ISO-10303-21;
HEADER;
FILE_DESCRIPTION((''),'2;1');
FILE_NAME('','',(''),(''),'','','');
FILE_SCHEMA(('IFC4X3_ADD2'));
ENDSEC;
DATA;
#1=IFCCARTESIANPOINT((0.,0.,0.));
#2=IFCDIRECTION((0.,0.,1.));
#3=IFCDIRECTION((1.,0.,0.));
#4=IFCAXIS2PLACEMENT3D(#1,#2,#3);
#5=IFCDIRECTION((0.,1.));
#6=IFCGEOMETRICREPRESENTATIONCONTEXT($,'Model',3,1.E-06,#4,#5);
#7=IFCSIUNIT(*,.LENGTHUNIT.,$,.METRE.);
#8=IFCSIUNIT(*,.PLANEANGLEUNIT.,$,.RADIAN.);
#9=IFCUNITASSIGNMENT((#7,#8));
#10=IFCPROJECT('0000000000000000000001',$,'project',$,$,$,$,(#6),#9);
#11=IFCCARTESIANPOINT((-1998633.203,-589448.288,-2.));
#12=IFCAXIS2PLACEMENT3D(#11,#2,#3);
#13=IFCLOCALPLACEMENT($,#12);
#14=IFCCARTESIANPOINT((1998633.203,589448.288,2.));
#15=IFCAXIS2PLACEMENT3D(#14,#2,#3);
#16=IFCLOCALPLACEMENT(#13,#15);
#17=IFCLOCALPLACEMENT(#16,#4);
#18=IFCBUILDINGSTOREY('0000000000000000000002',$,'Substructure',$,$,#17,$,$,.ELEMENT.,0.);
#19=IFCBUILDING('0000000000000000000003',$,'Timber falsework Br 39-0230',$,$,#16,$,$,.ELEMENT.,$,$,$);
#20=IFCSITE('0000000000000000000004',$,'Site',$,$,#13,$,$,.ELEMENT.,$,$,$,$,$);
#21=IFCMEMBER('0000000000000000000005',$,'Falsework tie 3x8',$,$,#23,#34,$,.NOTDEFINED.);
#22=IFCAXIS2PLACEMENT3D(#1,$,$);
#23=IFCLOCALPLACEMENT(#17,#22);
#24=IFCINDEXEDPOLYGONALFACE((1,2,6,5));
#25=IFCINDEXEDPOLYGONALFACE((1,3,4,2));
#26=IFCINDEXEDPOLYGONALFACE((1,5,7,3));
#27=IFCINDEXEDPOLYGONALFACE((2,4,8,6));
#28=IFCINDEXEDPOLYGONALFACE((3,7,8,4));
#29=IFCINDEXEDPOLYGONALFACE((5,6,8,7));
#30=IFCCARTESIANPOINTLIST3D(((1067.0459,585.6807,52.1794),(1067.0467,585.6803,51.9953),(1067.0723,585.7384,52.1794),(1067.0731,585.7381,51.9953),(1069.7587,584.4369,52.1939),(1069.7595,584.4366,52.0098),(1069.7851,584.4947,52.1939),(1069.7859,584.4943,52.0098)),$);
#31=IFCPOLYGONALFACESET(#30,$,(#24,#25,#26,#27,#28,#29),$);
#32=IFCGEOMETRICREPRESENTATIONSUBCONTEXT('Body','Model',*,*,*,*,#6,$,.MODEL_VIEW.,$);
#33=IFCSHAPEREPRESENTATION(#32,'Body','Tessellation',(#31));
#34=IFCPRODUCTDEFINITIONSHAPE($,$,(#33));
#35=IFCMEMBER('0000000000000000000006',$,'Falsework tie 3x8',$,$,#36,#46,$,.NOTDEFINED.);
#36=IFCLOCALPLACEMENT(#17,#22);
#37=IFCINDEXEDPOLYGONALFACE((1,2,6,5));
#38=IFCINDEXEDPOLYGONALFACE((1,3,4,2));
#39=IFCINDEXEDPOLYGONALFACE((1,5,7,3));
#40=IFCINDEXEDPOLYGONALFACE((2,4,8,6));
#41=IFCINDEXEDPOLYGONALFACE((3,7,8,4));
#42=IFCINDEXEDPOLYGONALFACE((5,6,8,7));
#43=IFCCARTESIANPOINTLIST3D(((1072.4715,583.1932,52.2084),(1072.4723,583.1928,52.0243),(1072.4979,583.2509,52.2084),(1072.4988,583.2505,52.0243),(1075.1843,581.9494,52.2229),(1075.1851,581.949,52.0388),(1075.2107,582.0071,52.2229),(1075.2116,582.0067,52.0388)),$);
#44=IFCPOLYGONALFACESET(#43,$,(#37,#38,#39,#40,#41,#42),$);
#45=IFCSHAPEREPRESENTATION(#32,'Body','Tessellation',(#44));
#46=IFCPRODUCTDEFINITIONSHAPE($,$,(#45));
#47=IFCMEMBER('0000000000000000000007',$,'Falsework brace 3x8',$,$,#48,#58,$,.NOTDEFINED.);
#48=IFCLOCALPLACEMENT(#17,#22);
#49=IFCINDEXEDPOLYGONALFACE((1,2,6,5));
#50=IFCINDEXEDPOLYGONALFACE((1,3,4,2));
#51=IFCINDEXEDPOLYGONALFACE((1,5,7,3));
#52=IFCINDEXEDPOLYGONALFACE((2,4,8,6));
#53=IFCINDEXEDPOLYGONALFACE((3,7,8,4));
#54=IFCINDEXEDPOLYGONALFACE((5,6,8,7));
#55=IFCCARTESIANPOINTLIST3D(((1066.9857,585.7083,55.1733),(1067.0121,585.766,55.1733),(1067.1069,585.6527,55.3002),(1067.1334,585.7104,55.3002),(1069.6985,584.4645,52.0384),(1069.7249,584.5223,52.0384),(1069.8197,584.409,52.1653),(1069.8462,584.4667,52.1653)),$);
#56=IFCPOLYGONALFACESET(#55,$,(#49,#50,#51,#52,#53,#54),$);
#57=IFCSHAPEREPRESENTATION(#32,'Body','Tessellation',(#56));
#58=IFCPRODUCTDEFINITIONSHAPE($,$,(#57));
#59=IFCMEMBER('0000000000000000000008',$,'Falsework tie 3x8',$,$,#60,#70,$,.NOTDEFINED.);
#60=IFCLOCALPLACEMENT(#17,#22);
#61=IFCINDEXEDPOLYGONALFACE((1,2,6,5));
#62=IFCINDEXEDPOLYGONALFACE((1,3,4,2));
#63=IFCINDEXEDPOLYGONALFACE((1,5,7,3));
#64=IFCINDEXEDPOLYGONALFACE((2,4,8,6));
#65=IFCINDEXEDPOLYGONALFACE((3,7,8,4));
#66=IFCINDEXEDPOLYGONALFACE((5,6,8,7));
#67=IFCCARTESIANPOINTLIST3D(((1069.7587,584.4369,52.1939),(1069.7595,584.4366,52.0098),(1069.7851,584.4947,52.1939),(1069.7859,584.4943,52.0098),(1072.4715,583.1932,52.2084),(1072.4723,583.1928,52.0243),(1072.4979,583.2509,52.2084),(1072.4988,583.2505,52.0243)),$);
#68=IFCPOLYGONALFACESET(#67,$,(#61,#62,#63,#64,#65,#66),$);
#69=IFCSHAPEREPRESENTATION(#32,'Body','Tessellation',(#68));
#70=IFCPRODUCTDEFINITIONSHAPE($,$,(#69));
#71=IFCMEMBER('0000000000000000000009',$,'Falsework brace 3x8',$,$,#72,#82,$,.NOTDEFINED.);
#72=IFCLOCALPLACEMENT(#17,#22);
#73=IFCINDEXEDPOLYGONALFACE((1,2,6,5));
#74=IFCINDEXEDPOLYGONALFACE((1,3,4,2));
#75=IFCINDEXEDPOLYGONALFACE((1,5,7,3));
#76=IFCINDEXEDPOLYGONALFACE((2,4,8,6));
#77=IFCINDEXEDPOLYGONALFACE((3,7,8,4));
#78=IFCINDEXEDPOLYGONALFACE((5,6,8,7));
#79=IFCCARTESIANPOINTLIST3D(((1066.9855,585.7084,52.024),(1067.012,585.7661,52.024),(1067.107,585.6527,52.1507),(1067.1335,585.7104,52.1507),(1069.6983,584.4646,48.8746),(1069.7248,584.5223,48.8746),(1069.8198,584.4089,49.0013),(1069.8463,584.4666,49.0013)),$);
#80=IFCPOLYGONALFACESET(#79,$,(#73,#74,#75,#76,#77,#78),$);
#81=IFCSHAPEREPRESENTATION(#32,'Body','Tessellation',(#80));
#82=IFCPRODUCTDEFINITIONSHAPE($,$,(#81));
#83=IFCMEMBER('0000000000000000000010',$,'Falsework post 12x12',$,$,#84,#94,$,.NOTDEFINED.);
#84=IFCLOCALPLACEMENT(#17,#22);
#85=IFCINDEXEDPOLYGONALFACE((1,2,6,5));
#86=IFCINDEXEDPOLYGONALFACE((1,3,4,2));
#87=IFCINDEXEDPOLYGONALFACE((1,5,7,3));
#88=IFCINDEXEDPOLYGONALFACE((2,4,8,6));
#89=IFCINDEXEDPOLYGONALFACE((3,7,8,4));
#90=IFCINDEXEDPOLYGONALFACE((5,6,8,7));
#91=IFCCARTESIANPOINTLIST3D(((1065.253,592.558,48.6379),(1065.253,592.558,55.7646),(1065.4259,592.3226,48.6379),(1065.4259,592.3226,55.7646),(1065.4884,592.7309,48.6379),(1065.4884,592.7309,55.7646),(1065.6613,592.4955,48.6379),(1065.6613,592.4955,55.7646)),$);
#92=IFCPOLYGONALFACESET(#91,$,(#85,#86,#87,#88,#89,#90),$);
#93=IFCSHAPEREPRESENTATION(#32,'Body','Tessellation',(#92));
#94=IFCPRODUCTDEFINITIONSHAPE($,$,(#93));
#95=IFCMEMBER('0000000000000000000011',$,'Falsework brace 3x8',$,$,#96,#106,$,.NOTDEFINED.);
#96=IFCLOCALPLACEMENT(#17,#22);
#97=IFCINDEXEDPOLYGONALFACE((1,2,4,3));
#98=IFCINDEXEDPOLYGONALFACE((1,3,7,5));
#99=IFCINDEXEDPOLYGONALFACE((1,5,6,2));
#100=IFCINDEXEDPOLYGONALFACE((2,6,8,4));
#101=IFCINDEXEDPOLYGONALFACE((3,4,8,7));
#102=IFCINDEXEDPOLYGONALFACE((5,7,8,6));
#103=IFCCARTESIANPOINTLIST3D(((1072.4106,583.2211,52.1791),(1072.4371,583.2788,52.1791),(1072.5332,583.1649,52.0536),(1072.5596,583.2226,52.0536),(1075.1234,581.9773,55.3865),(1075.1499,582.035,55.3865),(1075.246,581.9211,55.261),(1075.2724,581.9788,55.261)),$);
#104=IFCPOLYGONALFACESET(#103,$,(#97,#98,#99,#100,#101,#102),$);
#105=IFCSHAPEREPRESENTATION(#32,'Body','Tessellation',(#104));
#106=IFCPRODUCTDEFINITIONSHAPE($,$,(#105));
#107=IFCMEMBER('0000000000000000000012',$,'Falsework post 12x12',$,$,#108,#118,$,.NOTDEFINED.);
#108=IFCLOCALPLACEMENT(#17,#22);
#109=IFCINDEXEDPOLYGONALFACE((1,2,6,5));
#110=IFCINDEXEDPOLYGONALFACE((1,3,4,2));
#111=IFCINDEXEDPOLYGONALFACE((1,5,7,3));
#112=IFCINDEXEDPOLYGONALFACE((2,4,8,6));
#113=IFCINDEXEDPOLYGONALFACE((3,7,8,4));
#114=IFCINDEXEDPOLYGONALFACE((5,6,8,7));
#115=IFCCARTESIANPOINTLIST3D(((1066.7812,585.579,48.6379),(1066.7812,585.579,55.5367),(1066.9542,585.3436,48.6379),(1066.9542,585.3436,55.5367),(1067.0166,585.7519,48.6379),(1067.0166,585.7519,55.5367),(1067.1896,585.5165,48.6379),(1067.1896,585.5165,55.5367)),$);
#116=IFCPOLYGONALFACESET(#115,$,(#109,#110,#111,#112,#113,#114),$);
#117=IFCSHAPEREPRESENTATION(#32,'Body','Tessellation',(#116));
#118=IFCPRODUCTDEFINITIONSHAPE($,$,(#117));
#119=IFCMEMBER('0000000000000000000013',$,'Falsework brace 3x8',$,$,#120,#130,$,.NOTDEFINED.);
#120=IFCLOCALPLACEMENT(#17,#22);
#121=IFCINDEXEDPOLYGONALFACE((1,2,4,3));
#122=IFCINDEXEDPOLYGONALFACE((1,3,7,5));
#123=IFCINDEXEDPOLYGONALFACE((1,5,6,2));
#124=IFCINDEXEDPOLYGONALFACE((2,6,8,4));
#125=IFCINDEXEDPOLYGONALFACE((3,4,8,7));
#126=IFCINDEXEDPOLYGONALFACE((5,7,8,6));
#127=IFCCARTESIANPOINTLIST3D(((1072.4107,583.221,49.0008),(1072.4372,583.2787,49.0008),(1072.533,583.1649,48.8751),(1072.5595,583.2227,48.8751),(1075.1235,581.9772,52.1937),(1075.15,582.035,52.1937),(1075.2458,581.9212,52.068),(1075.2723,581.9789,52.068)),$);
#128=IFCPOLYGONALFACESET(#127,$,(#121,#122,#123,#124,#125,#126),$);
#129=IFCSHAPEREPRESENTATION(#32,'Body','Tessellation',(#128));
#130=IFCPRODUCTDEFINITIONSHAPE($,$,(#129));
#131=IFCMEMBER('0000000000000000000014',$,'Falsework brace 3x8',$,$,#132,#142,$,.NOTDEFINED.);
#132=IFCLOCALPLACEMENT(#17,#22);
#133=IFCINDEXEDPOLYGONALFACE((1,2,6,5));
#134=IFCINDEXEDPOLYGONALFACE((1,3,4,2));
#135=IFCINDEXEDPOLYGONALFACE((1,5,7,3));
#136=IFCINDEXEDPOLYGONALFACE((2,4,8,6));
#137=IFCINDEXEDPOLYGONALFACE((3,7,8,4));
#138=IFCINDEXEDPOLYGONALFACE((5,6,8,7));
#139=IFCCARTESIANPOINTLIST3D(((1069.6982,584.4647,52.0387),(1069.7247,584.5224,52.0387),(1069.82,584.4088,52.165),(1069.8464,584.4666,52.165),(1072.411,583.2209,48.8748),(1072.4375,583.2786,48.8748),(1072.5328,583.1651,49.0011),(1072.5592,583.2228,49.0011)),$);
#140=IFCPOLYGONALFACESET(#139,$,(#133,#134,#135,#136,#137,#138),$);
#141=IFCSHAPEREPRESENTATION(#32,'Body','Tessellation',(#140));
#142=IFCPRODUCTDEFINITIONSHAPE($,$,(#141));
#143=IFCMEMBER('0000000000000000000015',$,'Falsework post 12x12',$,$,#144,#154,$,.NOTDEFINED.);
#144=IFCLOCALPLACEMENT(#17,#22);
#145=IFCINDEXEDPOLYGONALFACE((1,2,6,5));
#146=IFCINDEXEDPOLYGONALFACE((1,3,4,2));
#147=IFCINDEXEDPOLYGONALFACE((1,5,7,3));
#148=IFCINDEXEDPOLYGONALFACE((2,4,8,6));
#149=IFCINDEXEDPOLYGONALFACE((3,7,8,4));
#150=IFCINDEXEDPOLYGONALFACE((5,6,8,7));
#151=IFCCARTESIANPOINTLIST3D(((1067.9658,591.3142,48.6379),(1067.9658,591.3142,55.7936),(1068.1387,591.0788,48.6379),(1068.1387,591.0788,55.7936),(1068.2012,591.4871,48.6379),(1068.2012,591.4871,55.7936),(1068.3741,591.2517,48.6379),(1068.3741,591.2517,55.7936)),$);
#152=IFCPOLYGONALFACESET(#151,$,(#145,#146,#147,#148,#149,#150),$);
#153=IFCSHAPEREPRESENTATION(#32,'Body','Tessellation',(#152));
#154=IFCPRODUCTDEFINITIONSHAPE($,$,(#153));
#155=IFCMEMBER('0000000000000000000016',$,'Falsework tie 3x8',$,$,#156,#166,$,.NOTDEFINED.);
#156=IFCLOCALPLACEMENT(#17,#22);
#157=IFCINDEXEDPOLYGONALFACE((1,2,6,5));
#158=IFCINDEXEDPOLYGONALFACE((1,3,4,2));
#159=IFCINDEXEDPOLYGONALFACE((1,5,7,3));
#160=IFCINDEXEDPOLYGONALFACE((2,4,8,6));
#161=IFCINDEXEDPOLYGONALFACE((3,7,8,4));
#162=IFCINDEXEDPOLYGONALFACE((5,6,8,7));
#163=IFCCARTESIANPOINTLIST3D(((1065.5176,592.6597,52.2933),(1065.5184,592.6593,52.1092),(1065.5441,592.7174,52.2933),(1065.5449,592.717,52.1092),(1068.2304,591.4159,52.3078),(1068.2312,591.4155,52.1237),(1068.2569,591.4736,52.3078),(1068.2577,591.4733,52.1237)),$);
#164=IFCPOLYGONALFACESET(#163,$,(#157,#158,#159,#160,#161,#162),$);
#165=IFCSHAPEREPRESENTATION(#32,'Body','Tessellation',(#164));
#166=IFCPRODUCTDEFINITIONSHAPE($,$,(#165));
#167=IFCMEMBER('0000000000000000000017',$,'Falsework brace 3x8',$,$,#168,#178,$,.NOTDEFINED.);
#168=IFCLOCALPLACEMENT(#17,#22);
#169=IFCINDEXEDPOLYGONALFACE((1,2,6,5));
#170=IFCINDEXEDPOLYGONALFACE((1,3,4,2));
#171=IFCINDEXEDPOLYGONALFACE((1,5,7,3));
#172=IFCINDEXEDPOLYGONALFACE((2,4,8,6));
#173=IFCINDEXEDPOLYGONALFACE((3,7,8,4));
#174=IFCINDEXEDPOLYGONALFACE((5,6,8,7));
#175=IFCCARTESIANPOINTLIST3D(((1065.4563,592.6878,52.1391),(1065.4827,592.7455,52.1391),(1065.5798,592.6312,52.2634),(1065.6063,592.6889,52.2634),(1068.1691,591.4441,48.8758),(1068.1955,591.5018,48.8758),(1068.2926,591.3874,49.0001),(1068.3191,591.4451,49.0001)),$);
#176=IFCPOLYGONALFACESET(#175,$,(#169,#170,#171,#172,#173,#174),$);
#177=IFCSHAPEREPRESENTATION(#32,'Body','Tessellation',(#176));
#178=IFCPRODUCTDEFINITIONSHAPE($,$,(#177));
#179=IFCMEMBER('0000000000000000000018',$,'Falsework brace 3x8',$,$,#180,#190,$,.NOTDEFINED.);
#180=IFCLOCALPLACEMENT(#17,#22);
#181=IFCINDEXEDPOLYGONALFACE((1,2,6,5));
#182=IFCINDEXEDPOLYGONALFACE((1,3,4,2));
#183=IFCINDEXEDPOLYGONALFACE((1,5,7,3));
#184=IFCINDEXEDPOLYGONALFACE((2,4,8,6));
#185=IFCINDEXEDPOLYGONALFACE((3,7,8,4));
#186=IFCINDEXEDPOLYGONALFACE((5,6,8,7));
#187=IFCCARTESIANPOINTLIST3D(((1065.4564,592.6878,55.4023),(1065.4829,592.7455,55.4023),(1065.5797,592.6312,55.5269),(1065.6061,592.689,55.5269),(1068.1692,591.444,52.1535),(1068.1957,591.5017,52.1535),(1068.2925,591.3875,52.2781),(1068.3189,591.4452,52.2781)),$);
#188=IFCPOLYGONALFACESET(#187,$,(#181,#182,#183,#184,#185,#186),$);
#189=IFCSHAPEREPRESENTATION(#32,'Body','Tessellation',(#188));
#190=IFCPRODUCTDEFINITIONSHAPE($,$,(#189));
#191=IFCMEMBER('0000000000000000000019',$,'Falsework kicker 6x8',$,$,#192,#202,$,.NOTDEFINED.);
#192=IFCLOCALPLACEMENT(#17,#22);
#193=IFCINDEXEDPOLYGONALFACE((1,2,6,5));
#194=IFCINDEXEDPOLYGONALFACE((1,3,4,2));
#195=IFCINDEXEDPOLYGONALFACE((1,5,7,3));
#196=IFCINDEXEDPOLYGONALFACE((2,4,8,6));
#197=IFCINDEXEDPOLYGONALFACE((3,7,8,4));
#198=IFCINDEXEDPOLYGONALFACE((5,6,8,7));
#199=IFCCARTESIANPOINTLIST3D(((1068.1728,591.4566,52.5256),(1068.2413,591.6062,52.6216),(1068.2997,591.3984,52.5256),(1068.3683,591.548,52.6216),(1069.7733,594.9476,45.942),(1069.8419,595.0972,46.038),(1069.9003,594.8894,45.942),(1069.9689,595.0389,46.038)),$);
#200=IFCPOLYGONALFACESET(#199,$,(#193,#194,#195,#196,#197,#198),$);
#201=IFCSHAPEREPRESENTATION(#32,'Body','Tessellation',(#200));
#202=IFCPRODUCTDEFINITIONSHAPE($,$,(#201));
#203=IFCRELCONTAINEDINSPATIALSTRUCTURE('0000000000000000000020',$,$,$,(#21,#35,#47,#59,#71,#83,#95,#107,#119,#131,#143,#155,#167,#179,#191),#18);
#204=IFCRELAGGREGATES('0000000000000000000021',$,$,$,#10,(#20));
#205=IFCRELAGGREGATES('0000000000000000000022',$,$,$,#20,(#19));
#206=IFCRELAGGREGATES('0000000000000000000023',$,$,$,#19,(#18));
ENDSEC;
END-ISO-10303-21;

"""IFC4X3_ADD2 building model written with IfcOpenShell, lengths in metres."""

from ifc_helpers import new_model, si_unit, direction, frame, origin, origin_with_axes, origin_2d, place, context, subcontext, project, spatial, rectangle, extrude, element, save


model = new_model("IFC4X3_ADD2")

# Units and contexts
model_context = context("Model", 3, precision=1e-06, world=origin_with_axes(), true_north=direction((0.0, 1.0)))
body_context = subcontext(model_context, "Body", "Model", "MODEL_VIEW")
ifc_project = project(units=[si_unit("LENGTHUNIT", "METRE"), si_unit("PLANEANGLEUNIT", "RADIAN")], contexts=[model_context])

# Site, building, storey
site_placement = place(None, frame((-1998633.203, -589448.288, -2.0), z_axis=(0.0, 0.0, 1.0), x_axis=(1.0, 0.0, 0.0)))
site = spatial("IfcSite", under=ifc_project, at=site_placement, Name="Site", CompositionType="ELEMENT")
building_placement = place(site_placement, frame((1998633.203, 589448.288, 2.0), z_axis=(0.0, 0.0, 1.0), x_axis=(1.0, 0.0, 0.0)))
building = spatial("IfcBuilding", under=site, at=building_placement, Name="Timber falsework Br 39-0230", CompositionType="ELEMENT")
storey_placement = place(building_placement, origin_with_axes())
storey = spatial("IfcBuildingStorey", under=building, at=storey_placement, Name="Substructure", CompositionType="ELEMENT", Elevation=0.0)

# Members
for number, where, z_axis, x_axis, name in (
    (1, (1067.0595, 585.7094, 52.0873), (0.909003, -0.41676, 0.004859), (0.416765, 0.909014, 0.0), "Falsework tie 3x8"),
    (2, (1072.4851, 583.2218, 52.1163), (0.909003, -0.41676, 0.004859), (0.416765, 0.909014, 0.0), "Falsework tie 3x8"),
):
    element("IfcMember", number, at=place(storey_placement, frame(where, z_axis=z_axis, x_axis=x_axis)), inside=storey, Name=name, PredefinedType="NOTDEFINED", context=body_context, shape_type="SweptSolid", body=[
        extrude(rectangle(XDim=0.0635, YDim=0.1841, at=origin_2d()), origin(), (0.0, 0.0, 1.0), 2.9844),
    ])
member_1_placement = place(storey_placement, frame((1067.0595, 585.7094, 55.2367), z_axis=(0.626765, -0.28736, -0.724285), x_axis=(0.416765, 0.909014, 0.0)))
element("IfcMember", 3, at=member_1_placement, inside=storey, Name="Falsework brace 3x8", PredefinedType="NOTDEFINED", context=body_context, shape_type="SweptSolid", body=[
    extrude(rectangle(XDim=0.0635, YDim=0.1841, at=origin_2d()), origin(), (0.0, 0.0, 1.0), 4.3283),
])
member_2_placement = place(storey_placement, frame((1069.7723, 584.4656, 52.1018), z_axis=(0.909003, -0.41676, 0.004859), x_axis=(0.416765, 0.909014, 0.0)))
element("IfcMember", 4, at=member_2_placement, inside=storey, Name="Falsework tie 3x8", PredefinedType="NOTDEFINED", context=body_context, shape_type="SweptSolid", body=[
    extrude(rectangle(XDim=0.0635, YDim=0.1841, at=origin_2d()), origin(), (0.0, 0.0, 1.0), 2.9844),
])
member_3_placement = place(storey_placement, frame((1067.0595, 585.7094, 52.0873), z_axis=(0.625247, -0.286663, -0.725872), x_axis=(0.416765, 0.909014, 0.0)))
element("IfcMember", 5, at=member_3_placement, inside=storey, Name="Falsework brace 3x8", PredefinedType="NOTDEFINED", context=body_context, shape_type="SweptSolid", body=[
    extrude(rectangle(XDim=0.0635, YDim=0.1841, at=origin_2d()), origin(), (0.0, 0.0, 1.0), 4.3388),
])
member_4_placement = place(storey_placement, frame((1065.4572, 592.5267, 48.6379), z_axis=(0.0, 0.0, 1.0), x_axis=(-0.805928, -0.592013, 0.0)))
element("IfcMember", 6, at=member_4_placement, inside=storey, Name="Falsework post 12x12", PredefinedType="NOTDEFINED", context=body_context, shape_type="SweptSolid", body=[
    extrude(rectangle(XDim=0.2921, YDim=0.2921, at=origin_2d()), origin(), (0.0, 0.0, 1.0), 7.1267),
])
member_5_placement = place(storey_placement, frame((1072.4851, 583.2218, 52.1163), z_axis=(0.619212, -0.283897, 0.732106), x_axis=(0.416765, 0.909014, 0.0)))
element("IfcMember", 7, at=member_5_placement, inside=storey, Name="Falsework brace 3x8", PredefinedType="NOTDEFINED", context=body_context, shape_type="SweptSolid", body=[
    extrude(rectangle(XDim=0.0635, YDim=0.1841, at=origin_2d()), origin(), (0.0, 0.0, 1.0), 4.3811),
])
member_6_placement = place(storey_placement, frame((1066.9854, 585.5478, 48.6379), z_axis=(0.0, 0.0, 1.0), x_axis=(-0.805928, -0.592013, 0.0)))
element("IfcMember", 8, at=member_6_placement, inside=storey, Name="Falsework post 12x12", PredefinedType="NOTDEFINED", context=body_context, shape_type="SweptSolid", body=[
    extrude(rectangle(XDim=0.2921, YDim=0.2921, at=origin_2d()), origin(), (0.0, 0.0, 1.0), 6.8988),
])
member_7_placement = place(storey_placement, frame((1072.4851, 583.2218, 48.9379), z_axis=(0.620715, -0.284586, 0.730564), x_axis=(0.416765, 0.909014, 0.0)))
element("IfcMember", 9, at=member_7_placement, inside=storey, Name="Falsework brace 3x8", PredefinedType="NOTDEFINED", context=body_context, shape_type="SweptSolid", body=[
    extrude(rectangle(XDim=0.0635, YDim=0.1841, at=origin_2d()), origin(), (0.0, 0.0, 1.0), 4.3705),
])
member_8_placement = place(storey_placement, frame((1069.7723, 584.4656, 52.1018), z_axis=(0.623732, -0.285969, -0.727448), x_axis=(0.416765, 0.909014, 0.0)))
element("IfcMember", 10, at=member_8_placement, inside=storey, Name="Falsework brace 3x8", PredefinedType="NOTDEFINED", context=body_context, shape_type="SweptSolid", body=[
    extrude(rectangle(XDim=0.0635, YDim=0.1841, at=origin_2d()), origin(), (0.0, 0.0, 1.0), 4.3493),
])
member_9_placement = place(storey_placement, frame((1068.17, 591.283, 48.6379), z_axis=(0.0, 0.0, 1.0), x_axis=(-0.805928, -0.592013, 0.0)))
element("IfcMember", 11, at=member_9_placement, inside=storey, Name="Falsework post 12x12", PredefinedType="NOTDEFINED", context=body_context, shape_type="SweptSolid", body=[
    extrude(rectangle(XDim=0.2921, YDim=0.2921, at=origin_2d()), origin(), (0.0, 0.0, 1.0), 7.1557),
])
member_10_placement = place(storey_placement, frame((1065.5313, 592.6884, 52.2013), z_axis=(0.909003, -0.41676, 0.004859), x_axis=(0.416765, 0.909014, 0.0)))
element("IfcMember", 12, at=member_10_placement, inside=storey, Name="Falsework tie 3x8", PredefinedType="NOTDEFINED", context=body_context, shape_type="SweptSolid", body=[
    extrude(rectangle(XDim=0.0635, YDim=0.1841, at=origin_2d()), origin(), (0.0, 0.0, 1.0), 2.9844),
])
member_11_placement = place(storey_placement, frame((1065.5313, 592.6884, 52.2013), z_axis=(0.613455, -0.281257, -0.737948), x_axis=(0.416765, 0.909014, 0.0)))
element("IfcMember", 13, at=member_11_placement, inside=storey, Name="Falsework brace 3x8", PredefinedType="NOTDEFINED", context=body_context, shape_type="SweptSolid", body=[
    extrude(rectangle(XDim=0.0635, YDim=0.1841, at=origin_2d()), origin(), (0.0, 0.0, 1.0), 4.4222),
])
member_12_placement = place(storey_placement, frame((1065.5313, 592.6884, 55.4646), z_axis=(0.614942, -0.281939, -0.736449), x_axis=(0.416765, 0.909014, 0.0)))
element("IfcMember", 14, at=member_12_placement, inside=storey, Name="Falsework brace 3x8", PredefinedType="NOTDEFINED", context=body_context, shape_type="SweptSolid", body=[
    extrude(rectangle(XDim=0.0635, YDim=0.1841, at=origin_2d()), origin(), (0.0, 0.0, 1.0), 4.4115),
])
member_13_placement = place(storey_placement, frame((1068.2705, 591.5023, 52.5736), z_axis=(0.209994, 0.458022, -0.863781), x_axis=(-0.909014, 0.416765, 0.0)))
element("IfcMember", 15, at=member_13_placement, inside=storey, Name="Falsework kicker 6x8", PredefinedType="NOTDEFINED", context=body_context, shape_type="SweptSolid", body=[
    extrude(rectangle(XDim=0.1397, YDim=0.1905, at=origin_2d()), origin(), (0.0, 0.0, 1.0), 7.6218),
])

save(model, "model.ifc")
